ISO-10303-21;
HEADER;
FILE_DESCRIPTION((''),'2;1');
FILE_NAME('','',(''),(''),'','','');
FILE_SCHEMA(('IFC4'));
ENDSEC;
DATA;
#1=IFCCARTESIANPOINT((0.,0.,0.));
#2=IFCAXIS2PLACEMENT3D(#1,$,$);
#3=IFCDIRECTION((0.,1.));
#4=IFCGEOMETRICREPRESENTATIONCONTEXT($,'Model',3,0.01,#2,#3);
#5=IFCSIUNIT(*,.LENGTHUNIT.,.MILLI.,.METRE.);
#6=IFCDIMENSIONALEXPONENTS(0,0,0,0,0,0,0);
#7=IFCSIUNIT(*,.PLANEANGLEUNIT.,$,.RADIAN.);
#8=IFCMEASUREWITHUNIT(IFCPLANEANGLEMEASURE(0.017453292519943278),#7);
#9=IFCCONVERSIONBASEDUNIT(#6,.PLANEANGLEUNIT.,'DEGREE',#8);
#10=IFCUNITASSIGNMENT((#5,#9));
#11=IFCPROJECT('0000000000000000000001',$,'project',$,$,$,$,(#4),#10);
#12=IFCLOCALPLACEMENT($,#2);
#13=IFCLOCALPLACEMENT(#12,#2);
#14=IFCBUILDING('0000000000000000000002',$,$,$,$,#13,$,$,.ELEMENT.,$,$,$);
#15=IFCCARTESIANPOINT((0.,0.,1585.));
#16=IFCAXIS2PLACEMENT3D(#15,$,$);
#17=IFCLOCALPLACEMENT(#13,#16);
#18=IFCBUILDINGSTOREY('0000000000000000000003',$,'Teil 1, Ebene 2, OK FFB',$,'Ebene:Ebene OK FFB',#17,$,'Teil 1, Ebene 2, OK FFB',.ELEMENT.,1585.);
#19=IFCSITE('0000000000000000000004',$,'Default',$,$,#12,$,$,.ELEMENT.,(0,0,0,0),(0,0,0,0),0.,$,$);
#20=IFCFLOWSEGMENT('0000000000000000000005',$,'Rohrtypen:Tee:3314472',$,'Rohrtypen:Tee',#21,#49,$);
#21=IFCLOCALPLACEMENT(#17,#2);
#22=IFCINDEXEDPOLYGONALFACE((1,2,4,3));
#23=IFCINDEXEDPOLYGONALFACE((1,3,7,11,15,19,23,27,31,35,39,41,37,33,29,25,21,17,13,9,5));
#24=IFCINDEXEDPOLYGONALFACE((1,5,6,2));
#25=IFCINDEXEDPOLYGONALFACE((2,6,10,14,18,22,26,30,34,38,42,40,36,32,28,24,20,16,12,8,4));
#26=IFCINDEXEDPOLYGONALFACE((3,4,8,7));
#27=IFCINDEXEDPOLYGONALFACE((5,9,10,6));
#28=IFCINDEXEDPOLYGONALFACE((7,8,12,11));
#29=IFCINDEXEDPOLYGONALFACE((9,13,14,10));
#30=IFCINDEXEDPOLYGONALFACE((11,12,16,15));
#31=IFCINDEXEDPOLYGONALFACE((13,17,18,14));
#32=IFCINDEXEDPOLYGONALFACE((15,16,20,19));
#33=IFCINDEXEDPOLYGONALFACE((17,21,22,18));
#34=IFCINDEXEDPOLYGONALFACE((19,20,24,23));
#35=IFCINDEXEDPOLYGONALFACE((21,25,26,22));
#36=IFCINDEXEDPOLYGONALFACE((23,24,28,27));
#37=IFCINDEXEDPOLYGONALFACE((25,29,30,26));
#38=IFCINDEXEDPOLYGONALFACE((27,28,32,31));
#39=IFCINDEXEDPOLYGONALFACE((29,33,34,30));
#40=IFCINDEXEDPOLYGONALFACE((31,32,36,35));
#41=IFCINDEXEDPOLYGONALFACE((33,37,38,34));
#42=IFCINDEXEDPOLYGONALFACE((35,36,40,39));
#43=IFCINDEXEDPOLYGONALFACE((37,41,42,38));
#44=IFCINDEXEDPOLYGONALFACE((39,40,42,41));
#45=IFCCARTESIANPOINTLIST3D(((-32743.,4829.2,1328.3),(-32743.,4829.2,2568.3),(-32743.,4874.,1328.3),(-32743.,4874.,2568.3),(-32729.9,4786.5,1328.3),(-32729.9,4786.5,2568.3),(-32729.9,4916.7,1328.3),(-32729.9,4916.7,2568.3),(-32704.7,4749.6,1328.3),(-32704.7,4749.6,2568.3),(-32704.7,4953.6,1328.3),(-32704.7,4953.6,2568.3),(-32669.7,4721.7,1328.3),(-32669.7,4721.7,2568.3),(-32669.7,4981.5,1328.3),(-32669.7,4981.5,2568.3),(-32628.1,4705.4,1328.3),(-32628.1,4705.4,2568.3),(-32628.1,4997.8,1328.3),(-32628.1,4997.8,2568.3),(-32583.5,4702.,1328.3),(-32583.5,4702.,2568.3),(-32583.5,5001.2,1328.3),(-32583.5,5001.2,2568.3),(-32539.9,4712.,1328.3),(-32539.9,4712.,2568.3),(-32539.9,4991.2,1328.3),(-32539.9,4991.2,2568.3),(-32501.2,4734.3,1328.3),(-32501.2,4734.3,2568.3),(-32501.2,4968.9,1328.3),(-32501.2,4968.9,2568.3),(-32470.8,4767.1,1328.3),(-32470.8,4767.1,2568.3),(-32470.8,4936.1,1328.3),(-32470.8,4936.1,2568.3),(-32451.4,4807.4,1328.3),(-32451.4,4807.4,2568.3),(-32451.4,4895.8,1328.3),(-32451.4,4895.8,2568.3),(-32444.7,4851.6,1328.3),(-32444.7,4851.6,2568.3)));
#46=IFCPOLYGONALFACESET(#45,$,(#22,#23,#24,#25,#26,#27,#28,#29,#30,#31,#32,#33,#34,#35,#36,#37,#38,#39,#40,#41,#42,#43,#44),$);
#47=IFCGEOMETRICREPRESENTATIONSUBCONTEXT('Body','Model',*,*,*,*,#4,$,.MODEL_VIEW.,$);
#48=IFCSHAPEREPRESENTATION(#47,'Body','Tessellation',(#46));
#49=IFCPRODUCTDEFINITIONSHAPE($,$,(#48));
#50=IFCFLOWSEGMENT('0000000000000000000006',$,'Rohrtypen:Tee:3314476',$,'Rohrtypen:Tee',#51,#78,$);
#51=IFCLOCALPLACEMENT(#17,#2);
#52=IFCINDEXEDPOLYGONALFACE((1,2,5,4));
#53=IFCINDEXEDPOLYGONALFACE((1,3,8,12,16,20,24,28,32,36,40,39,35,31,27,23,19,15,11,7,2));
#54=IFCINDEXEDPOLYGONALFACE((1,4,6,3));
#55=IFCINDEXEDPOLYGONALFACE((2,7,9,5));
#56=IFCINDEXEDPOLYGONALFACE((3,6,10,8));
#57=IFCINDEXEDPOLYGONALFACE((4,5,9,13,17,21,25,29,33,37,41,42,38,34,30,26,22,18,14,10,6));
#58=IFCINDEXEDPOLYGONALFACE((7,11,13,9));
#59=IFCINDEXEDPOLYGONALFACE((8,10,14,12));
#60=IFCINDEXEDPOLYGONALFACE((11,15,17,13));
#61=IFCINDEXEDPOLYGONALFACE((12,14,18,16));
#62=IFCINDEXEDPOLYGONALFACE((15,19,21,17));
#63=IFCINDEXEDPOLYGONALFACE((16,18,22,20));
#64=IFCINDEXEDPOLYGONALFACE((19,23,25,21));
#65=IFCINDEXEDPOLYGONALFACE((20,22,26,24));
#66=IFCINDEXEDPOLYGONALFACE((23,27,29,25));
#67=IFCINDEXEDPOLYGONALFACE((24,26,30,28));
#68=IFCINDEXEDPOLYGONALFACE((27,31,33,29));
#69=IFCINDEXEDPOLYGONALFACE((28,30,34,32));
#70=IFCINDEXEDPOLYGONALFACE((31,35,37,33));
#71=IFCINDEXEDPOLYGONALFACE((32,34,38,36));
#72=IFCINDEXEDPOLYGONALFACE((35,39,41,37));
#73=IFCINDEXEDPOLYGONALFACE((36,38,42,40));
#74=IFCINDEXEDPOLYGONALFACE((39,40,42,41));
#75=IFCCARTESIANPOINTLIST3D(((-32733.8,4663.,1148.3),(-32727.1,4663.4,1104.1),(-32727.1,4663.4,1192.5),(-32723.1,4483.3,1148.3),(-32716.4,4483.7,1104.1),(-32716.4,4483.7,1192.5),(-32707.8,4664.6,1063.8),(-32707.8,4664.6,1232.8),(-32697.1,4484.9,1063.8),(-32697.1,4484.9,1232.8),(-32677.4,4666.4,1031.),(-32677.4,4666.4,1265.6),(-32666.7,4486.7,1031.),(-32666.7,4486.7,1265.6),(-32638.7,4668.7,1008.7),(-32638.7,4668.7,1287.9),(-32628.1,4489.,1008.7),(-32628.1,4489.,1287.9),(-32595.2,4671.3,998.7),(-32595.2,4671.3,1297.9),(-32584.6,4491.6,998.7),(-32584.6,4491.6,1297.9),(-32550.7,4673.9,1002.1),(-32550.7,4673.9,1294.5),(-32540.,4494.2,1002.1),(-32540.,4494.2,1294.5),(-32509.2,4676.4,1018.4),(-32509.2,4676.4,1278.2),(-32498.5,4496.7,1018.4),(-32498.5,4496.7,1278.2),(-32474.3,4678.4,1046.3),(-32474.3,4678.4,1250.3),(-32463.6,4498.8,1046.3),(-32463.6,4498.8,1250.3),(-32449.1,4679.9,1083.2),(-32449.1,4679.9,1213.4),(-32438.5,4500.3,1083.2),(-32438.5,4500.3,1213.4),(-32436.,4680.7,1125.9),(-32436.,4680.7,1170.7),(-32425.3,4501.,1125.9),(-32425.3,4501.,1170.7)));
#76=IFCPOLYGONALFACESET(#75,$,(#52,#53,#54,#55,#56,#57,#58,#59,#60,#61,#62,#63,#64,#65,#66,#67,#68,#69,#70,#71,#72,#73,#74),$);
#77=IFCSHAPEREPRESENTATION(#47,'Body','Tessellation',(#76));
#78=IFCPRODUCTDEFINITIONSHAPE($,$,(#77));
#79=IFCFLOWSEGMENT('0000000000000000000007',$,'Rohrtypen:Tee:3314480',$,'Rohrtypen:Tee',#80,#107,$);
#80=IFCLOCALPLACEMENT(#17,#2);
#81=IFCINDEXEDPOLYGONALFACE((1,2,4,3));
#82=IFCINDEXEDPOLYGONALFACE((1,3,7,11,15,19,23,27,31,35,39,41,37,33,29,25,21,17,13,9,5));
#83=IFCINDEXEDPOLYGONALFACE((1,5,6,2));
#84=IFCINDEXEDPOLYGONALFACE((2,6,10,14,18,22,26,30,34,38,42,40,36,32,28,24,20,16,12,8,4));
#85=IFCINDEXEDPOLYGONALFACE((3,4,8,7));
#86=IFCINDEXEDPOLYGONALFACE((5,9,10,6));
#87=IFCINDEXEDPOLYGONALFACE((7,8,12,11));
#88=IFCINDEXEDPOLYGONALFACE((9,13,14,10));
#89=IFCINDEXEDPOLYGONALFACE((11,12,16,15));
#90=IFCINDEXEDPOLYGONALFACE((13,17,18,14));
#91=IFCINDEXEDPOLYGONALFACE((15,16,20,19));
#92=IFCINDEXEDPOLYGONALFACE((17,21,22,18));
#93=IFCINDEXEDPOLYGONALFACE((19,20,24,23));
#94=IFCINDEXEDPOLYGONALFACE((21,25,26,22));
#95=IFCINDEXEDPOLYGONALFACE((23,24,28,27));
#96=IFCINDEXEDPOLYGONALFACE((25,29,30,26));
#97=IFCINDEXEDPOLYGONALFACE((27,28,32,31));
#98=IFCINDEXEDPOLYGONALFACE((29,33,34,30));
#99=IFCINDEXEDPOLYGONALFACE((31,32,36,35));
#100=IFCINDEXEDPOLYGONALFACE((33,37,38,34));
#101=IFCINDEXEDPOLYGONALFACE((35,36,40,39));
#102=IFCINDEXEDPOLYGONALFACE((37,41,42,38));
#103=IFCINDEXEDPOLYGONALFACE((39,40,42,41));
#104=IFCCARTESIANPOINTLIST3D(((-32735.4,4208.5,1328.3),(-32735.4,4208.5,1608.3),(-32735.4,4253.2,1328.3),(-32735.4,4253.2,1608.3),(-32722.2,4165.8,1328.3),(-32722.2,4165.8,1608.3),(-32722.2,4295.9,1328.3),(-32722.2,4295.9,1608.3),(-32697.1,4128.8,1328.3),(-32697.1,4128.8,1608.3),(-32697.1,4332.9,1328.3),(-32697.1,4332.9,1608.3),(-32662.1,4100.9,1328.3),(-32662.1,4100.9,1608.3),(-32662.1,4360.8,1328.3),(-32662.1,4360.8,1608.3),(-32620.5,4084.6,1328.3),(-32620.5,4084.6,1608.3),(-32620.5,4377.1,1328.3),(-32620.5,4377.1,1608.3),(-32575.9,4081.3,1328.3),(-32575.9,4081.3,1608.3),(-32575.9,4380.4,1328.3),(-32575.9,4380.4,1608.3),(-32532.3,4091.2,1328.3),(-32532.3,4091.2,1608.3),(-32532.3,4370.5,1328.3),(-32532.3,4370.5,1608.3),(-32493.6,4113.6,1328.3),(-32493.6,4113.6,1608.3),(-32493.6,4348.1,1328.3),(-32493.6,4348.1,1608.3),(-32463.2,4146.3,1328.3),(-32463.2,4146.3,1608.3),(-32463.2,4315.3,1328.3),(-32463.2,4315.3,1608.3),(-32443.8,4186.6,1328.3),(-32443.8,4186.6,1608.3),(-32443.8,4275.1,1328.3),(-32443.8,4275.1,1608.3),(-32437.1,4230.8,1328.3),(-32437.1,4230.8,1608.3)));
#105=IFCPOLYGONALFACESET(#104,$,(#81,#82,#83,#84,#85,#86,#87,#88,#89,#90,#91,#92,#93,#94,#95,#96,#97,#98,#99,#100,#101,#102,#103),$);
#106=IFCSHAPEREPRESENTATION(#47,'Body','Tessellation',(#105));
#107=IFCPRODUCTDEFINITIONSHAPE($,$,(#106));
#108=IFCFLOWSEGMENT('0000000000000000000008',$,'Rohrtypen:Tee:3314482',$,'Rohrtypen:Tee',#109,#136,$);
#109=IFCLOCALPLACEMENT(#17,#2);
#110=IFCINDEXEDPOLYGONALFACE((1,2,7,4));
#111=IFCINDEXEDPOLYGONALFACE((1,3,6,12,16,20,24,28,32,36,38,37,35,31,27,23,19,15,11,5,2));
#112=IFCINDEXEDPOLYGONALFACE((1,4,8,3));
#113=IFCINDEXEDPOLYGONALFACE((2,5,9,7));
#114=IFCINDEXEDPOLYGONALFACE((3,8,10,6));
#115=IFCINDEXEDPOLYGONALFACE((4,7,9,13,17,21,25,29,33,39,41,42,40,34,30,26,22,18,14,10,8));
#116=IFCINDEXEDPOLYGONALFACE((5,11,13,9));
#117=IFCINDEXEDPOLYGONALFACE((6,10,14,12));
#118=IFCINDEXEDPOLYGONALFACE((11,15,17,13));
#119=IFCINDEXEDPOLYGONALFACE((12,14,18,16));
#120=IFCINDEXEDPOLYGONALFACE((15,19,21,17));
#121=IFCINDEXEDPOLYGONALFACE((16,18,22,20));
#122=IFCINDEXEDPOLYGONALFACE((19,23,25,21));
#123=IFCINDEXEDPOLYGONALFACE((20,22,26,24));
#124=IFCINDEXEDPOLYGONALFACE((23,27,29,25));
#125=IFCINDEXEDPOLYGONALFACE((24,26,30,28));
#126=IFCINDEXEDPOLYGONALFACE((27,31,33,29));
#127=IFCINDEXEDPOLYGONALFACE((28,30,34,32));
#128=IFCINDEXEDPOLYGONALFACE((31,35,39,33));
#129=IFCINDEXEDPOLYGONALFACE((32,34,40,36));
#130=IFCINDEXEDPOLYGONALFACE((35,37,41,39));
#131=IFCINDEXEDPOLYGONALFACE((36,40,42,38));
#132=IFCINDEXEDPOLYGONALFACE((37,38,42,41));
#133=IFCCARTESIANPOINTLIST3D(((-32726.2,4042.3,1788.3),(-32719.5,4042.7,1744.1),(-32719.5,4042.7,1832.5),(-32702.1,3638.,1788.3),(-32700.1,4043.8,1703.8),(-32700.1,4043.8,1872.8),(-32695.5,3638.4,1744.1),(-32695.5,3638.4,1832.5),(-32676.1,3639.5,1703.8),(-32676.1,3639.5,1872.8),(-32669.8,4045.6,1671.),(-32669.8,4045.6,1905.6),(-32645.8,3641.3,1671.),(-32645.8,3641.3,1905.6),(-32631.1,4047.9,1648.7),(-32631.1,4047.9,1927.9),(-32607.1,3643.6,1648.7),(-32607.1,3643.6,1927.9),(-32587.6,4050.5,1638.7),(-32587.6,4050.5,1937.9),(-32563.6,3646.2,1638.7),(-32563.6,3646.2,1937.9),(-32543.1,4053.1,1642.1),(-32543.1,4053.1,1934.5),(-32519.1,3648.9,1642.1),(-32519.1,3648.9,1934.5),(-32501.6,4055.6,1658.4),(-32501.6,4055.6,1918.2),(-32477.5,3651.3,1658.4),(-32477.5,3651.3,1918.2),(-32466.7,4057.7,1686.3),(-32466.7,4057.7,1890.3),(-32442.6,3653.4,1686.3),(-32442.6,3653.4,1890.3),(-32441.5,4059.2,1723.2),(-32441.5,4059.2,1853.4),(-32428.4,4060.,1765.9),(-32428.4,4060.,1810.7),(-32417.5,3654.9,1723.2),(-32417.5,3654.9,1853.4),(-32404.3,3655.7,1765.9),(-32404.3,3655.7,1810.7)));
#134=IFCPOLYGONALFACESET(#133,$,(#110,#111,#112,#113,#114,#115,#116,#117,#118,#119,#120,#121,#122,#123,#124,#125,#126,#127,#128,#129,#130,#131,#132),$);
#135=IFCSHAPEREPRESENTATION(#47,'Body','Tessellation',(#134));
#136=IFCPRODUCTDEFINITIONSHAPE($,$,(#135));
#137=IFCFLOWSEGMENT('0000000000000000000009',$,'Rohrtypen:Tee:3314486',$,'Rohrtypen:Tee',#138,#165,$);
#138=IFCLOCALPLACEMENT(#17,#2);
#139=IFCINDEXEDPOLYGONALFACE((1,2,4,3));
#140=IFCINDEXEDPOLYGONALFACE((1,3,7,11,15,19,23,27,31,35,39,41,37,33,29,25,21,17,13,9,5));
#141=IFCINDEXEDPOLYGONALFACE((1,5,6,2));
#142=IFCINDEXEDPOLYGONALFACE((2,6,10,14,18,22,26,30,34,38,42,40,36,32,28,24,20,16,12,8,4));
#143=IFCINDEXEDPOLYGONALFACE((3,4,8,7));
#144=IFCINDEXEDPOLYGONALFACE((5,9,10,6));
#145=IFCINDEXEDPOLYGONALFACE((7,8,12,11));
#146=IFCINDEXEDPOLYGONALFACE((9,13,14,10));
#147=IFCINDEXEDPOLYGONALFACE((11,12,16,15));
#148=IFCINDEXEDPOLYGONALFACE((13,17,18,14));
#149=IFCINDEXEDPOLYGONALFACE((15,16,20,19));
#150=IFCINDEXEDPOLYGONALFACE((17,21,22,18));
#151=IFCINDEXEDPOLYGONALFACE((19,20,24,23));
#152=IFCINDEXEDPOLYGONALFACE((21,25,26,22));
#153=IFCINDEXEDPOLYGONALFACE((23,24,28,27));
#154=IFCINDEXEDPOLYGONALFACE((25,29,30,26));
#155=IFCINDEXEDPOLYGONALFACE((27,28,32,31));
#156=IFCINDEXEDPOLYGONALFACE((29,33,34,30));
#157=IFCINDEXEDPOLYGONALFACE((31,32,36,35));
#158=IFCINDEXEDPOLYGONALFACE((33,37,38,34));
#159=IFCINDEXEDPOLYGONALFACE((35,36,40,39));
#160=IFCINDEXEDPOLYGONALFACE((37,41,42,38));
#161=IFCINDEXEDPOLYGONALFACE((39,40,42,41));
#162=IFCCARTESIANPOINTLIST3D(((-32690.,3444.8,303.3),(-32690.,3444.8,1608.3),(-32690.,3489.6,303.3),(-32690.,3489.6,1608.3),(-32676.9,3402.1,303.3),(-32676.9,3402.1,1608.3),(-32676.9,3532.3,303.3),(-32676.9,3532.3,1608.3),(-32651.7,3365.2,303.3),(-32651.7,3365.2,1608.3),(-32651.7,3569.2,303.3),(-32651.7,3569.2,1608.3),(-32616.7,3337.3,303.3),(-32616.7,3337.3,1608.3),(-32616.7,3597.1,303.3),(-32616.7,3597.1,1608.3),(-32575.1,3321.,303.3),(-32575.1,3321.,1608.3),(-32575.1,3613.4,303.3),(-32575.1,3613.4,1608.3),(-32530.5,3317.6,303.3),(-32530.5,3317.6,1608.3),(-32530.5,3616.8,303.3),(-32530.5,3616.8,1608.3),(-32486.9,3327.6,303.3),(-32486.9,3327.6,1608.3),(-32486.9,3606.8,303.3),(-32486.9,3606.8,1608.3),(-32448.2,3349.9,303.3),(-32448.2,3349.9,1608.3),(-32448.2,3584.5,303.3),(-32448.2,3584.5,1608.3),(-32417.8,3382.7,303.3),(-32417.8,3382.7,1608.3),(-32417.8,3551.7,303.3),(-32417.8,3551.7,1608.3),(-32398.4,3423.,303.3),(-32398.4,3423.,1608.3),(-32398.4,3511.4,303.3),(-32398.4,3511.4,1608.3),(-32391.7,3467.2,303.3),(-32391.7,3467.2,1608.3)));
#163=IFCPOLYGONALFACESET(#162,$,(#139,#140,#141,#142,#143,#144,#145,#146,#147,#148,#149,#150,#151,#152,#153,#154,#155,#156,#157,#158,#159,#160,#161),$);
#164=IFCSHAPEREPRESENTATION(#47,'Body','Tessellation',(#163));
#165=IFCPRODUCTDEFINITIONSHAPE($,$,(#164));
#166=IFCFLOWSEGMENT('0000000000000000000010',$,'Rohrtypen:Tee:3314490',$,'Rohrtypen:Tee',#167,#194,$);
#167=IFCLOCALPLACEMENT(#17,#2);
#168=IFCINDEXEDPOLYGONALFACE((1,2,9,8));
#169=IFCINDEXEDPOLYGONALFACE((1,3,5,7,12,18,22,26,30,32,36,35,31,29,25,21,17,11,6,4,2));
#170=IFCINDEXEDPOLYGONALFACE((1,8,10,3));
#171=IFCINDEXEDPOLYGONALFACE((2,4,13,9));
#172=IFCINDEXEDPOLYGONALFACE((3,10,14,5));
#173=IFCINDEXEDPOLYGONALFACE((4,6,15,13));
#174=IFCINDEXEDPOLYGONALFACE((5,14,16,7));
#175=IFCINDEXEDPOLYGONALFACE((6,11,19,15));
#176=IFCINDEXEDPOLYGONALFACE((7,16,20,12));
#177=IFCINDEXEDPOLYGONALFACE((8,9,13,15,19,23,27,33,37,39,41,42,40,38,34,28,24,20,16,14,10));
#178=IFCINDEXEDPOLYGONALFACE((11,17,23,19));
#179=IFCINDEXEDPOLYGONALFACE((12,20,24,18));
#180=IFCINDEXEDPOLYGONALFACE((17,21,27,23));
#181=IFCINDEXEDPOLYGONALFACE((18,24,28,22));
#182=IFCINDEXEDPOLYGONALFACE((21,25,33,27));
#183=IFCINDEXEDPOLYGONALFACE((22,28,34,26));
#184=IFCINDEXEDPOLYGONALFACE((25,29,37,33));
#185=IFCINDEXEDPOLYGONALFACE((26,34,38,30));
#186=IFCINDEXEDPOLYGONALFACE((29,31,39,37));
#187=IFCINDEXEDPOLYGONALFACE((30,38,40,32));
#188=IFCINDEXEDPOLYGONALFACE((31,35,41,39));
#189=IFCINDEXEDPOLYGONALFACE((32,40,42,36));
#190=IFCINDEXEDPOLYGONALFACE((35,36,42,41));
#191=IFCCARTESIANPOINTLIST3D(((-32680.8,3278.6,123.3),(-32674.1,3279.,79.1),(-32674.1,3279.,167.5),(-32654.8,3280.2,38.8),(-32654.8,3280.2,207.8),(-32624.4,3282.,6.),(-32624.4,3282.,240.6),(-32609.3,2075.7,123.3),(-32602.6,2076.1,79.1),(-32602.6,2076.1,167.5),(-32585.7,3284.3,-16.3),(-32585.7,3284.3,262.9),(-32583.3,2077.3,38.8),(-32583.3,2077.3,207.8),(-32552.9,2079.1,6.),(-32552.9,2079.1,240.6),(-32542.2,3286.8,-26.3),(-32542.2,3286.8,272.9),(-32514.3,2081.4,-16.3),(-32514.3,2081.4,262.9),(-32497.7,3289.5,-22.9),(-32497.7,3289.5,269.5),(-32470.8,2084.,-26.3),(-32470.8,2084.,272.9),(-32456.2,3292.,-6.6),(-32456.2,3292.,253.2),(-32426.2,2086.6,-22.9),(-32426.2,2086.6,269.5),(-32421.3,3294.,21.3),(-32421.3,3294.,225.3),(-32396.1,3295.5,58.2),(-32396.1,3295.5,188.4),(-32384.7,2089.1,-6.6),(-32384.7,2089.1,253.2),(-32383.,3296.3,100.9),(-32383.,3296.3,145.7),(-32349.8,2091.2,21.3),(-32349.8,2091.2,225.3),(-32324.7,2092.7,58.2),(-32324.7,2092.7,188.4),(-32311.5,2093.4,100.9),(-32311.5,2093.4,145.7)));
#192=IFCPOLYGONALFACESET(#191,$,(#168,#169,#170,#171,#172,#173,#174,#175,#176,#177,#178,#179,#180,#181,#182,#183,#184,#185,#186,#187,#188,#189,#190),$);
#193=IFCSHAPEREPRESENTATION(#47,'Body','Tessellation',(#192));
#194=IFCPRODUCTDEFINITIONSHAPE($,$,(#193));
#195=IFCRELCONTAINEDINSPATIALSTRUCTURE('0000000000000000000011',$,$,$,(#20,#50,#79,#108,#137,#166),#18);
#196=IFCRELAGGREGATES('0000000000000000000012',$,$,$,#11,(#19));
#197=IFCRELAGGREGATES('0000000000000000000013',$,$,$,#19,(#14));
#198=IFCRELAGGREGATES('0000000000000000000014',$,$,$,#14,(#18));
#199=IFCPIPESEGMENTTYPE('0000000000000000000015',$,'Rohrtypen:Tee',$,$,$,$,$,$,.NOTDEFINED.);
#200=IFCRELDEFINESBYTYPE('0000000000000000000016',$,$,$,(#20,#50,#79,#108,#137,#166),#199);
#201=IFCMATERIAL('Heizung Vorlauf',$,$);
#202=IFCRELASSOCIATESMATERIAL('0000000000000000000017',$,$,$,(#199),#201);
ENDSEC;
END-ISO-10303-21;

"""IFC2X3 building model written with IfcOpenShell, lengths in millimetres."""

from ifc_helpers import new_model, entity, si_unit, converted_unit, direction, frame, frame_2d, origin, origin_2d_with_axis, place, context, subcontext, project, spatial, circle, extrude, material, type_object, element, save


model = new_model("IFC2X3")

# Units and contexts
model_context = context("Model", 3, precision=0.01, world=origin(), true_north=direction((0.0, 1.0)))
body_context = subcontext(model_context, "Body", "Model", "MODEL_VIEW")
ifc_project = project(units=[si_unit("LENGTHUNIT", "METRE", prefix="MILLI"), converted_unit("PLANEANGLEUNIT", "DEGREE", entity("IfcPlaneAngleMeasure", 0.017453292519943278), si_unit("PLANEANGLEUNIT", "RADIAN"), dimensions=[0, 0, 0, 0, 0, 0, 0])], contexts=[model_context])

# Site, building, storey
site_placement = place(None, origin())
site = spatial("IfcSite", under=ifc_project, at=site_placement, Name="Default", CompositionType="ELEMENT", RefLatitude=(0, 0, 0, 0), RefLongitude=(0, 0, 0, 0), RefElevation=0.0)
building_placement = place(site_placement, origin())
building = spatial("IfcBuilding", under=site, at=building_placement, CompositionType="ELEMENT")
storey_placement = place(building_placement, frame((0.0, 0.0, 1585.0)))
storey = spatial("IfcBuildingStorey", under=building, at=storey_placement, Name="Teil 1, Ebene 2, OK FFB", ObjectType="Ebene:Ebene OK FFB", LongName="Teil 1, Ebene 2, OK FFB", CompositionType="ELEMENT", Elevation=1585.0)

# Flow segments
ifc_material = material(Name="Heizung Vorlauf")
pipe_segment_type = type_object("IfcPipeSegmentType", Name="Rohrtypen:Tee", PredefinedType="NOTDEFINED", material=ifc_material)
flow_segment_1_placement = place(storey_placement, origin())
element("IfcFlowSegment", 1, at=flow_segment_1_placement, inside=storey, type_object=pipe_segment_type, Name="Rohrtypen:Tee:3314472", ObjectType="Rohrtypen:Tee", context=body_context, shape_type="SweptSolid", body=[
    extrude(circle(Radius=150.0, at=frame_2d((0.0, 0.0), x_axis=(1.0, 0.0))), frame((-32594.7, 4851.6, 1328.3)), (0.0, 0.0, 1.0), 1240.0),
])
flow_segment_2_placement = place(storey_placement, origin())
element("IfcFlowSegment", 2, at=flow_segment_2_placement, inside=storey, type_object=pipe_segment_type, Name="Rohrtypen:Tee:3314476", ObjectType="Rohrtypen:Tee", context=body_context, shape_type="SweptSolid", body=[
    extrude(circle(Radius=150.0, at=origin_2d_with_axis()), frame((-32584.0, 4671.9, 1148.3), z_axis=(0.059319, -0.998239, 0.0), x_axis=(-0.998239, -0.059319, 0.0)), (0.0, 0.0, 1.0), 180.0),
])
flow_segment_3_placement = place(storey_placement, origin())
element("IfcFlowSegment", 3, at=flow_segment_3_placement, inside=storey, type_object=pipe_segment_type, Name="Rohrtypen:Tee:3314480", ObjectType="Rohrtypen:Tee", context=body_context, shape_type="SweptSolid", body=[
    extrude(circle(Radius=150.0, at=frame_2d((0.0, 0.0), x_axis=(1.0, 0.0))), frame((-32587.1, 4230.8, 1328.3)), (0.0, 0.0, 1.0), 280.0),
])
flow_segment_4_placement = place(storey_placement, origin())
element("IfcFlowSegment", 4, at=flow_segment_4_placement, inside=storey, type_object=pipe_segment_type, Name="Rohrtypen:Tee:3314482", ObjectType="Rohrtypen:Tee", context=body_context, shape_type="SweptSolid", body=[
    extrude(circle(Radius=150.0, at=frame_2d((0.0, 0.0), x_axis=(1.0, 0.0))), frame((-32576.4, 4051.2, 1788.3), z_axis=(0.059319, -0.998239, 0.0), x_axis=(-0.998239, -0.059319, 0.0)), (0.0, 0.0, 1.0), 405.0),
])
flow_segment_5_placement = place(storey_placement, origin())
element("IfcFlowSegment", 5, at=flow_segment_5_placement, inside=storey, type_object=pipe_segment_type, Name="Rohrtypen:Tee:3314486", ObjectType="Rohrtypen:Tee", context=body_context, shape_type="SweptSolid", body=[
    extrude(circle(Radius=150.0, at=frame_2d((0.0, 0.0), x_axis=(1.0, 0.0))), frame((-32541.7, 3467.2, 303.3)), (0.0, 0.0, 1.0), 1305.0),
])
flow_segment_6_placement = place(storey_placement, origin())
element("IfcFlowSegment", 6, at=flow_segment_6_placement, inside=storey, type_object=pipe_segment_type, Name="Rohrtypen:Tee:3314490", ObjectType="Rohrtypen:Tee", context=body_context, shape_type="SweptSolid", body=[
    extrude(circle(Radius=150.0, at=frame_2d((0.0, 0.0), x_axis=(1.0, 0.0))), frame((-32459.6, 2084.6, 123.3), z_axis=(-0.059319, 0.998239, 0.0), x_axis=(-0.998239, -0.059319, 0.0)), (0.0, 0.0, 1.0), 1205.0),
])

save(model, "model.ifc")
